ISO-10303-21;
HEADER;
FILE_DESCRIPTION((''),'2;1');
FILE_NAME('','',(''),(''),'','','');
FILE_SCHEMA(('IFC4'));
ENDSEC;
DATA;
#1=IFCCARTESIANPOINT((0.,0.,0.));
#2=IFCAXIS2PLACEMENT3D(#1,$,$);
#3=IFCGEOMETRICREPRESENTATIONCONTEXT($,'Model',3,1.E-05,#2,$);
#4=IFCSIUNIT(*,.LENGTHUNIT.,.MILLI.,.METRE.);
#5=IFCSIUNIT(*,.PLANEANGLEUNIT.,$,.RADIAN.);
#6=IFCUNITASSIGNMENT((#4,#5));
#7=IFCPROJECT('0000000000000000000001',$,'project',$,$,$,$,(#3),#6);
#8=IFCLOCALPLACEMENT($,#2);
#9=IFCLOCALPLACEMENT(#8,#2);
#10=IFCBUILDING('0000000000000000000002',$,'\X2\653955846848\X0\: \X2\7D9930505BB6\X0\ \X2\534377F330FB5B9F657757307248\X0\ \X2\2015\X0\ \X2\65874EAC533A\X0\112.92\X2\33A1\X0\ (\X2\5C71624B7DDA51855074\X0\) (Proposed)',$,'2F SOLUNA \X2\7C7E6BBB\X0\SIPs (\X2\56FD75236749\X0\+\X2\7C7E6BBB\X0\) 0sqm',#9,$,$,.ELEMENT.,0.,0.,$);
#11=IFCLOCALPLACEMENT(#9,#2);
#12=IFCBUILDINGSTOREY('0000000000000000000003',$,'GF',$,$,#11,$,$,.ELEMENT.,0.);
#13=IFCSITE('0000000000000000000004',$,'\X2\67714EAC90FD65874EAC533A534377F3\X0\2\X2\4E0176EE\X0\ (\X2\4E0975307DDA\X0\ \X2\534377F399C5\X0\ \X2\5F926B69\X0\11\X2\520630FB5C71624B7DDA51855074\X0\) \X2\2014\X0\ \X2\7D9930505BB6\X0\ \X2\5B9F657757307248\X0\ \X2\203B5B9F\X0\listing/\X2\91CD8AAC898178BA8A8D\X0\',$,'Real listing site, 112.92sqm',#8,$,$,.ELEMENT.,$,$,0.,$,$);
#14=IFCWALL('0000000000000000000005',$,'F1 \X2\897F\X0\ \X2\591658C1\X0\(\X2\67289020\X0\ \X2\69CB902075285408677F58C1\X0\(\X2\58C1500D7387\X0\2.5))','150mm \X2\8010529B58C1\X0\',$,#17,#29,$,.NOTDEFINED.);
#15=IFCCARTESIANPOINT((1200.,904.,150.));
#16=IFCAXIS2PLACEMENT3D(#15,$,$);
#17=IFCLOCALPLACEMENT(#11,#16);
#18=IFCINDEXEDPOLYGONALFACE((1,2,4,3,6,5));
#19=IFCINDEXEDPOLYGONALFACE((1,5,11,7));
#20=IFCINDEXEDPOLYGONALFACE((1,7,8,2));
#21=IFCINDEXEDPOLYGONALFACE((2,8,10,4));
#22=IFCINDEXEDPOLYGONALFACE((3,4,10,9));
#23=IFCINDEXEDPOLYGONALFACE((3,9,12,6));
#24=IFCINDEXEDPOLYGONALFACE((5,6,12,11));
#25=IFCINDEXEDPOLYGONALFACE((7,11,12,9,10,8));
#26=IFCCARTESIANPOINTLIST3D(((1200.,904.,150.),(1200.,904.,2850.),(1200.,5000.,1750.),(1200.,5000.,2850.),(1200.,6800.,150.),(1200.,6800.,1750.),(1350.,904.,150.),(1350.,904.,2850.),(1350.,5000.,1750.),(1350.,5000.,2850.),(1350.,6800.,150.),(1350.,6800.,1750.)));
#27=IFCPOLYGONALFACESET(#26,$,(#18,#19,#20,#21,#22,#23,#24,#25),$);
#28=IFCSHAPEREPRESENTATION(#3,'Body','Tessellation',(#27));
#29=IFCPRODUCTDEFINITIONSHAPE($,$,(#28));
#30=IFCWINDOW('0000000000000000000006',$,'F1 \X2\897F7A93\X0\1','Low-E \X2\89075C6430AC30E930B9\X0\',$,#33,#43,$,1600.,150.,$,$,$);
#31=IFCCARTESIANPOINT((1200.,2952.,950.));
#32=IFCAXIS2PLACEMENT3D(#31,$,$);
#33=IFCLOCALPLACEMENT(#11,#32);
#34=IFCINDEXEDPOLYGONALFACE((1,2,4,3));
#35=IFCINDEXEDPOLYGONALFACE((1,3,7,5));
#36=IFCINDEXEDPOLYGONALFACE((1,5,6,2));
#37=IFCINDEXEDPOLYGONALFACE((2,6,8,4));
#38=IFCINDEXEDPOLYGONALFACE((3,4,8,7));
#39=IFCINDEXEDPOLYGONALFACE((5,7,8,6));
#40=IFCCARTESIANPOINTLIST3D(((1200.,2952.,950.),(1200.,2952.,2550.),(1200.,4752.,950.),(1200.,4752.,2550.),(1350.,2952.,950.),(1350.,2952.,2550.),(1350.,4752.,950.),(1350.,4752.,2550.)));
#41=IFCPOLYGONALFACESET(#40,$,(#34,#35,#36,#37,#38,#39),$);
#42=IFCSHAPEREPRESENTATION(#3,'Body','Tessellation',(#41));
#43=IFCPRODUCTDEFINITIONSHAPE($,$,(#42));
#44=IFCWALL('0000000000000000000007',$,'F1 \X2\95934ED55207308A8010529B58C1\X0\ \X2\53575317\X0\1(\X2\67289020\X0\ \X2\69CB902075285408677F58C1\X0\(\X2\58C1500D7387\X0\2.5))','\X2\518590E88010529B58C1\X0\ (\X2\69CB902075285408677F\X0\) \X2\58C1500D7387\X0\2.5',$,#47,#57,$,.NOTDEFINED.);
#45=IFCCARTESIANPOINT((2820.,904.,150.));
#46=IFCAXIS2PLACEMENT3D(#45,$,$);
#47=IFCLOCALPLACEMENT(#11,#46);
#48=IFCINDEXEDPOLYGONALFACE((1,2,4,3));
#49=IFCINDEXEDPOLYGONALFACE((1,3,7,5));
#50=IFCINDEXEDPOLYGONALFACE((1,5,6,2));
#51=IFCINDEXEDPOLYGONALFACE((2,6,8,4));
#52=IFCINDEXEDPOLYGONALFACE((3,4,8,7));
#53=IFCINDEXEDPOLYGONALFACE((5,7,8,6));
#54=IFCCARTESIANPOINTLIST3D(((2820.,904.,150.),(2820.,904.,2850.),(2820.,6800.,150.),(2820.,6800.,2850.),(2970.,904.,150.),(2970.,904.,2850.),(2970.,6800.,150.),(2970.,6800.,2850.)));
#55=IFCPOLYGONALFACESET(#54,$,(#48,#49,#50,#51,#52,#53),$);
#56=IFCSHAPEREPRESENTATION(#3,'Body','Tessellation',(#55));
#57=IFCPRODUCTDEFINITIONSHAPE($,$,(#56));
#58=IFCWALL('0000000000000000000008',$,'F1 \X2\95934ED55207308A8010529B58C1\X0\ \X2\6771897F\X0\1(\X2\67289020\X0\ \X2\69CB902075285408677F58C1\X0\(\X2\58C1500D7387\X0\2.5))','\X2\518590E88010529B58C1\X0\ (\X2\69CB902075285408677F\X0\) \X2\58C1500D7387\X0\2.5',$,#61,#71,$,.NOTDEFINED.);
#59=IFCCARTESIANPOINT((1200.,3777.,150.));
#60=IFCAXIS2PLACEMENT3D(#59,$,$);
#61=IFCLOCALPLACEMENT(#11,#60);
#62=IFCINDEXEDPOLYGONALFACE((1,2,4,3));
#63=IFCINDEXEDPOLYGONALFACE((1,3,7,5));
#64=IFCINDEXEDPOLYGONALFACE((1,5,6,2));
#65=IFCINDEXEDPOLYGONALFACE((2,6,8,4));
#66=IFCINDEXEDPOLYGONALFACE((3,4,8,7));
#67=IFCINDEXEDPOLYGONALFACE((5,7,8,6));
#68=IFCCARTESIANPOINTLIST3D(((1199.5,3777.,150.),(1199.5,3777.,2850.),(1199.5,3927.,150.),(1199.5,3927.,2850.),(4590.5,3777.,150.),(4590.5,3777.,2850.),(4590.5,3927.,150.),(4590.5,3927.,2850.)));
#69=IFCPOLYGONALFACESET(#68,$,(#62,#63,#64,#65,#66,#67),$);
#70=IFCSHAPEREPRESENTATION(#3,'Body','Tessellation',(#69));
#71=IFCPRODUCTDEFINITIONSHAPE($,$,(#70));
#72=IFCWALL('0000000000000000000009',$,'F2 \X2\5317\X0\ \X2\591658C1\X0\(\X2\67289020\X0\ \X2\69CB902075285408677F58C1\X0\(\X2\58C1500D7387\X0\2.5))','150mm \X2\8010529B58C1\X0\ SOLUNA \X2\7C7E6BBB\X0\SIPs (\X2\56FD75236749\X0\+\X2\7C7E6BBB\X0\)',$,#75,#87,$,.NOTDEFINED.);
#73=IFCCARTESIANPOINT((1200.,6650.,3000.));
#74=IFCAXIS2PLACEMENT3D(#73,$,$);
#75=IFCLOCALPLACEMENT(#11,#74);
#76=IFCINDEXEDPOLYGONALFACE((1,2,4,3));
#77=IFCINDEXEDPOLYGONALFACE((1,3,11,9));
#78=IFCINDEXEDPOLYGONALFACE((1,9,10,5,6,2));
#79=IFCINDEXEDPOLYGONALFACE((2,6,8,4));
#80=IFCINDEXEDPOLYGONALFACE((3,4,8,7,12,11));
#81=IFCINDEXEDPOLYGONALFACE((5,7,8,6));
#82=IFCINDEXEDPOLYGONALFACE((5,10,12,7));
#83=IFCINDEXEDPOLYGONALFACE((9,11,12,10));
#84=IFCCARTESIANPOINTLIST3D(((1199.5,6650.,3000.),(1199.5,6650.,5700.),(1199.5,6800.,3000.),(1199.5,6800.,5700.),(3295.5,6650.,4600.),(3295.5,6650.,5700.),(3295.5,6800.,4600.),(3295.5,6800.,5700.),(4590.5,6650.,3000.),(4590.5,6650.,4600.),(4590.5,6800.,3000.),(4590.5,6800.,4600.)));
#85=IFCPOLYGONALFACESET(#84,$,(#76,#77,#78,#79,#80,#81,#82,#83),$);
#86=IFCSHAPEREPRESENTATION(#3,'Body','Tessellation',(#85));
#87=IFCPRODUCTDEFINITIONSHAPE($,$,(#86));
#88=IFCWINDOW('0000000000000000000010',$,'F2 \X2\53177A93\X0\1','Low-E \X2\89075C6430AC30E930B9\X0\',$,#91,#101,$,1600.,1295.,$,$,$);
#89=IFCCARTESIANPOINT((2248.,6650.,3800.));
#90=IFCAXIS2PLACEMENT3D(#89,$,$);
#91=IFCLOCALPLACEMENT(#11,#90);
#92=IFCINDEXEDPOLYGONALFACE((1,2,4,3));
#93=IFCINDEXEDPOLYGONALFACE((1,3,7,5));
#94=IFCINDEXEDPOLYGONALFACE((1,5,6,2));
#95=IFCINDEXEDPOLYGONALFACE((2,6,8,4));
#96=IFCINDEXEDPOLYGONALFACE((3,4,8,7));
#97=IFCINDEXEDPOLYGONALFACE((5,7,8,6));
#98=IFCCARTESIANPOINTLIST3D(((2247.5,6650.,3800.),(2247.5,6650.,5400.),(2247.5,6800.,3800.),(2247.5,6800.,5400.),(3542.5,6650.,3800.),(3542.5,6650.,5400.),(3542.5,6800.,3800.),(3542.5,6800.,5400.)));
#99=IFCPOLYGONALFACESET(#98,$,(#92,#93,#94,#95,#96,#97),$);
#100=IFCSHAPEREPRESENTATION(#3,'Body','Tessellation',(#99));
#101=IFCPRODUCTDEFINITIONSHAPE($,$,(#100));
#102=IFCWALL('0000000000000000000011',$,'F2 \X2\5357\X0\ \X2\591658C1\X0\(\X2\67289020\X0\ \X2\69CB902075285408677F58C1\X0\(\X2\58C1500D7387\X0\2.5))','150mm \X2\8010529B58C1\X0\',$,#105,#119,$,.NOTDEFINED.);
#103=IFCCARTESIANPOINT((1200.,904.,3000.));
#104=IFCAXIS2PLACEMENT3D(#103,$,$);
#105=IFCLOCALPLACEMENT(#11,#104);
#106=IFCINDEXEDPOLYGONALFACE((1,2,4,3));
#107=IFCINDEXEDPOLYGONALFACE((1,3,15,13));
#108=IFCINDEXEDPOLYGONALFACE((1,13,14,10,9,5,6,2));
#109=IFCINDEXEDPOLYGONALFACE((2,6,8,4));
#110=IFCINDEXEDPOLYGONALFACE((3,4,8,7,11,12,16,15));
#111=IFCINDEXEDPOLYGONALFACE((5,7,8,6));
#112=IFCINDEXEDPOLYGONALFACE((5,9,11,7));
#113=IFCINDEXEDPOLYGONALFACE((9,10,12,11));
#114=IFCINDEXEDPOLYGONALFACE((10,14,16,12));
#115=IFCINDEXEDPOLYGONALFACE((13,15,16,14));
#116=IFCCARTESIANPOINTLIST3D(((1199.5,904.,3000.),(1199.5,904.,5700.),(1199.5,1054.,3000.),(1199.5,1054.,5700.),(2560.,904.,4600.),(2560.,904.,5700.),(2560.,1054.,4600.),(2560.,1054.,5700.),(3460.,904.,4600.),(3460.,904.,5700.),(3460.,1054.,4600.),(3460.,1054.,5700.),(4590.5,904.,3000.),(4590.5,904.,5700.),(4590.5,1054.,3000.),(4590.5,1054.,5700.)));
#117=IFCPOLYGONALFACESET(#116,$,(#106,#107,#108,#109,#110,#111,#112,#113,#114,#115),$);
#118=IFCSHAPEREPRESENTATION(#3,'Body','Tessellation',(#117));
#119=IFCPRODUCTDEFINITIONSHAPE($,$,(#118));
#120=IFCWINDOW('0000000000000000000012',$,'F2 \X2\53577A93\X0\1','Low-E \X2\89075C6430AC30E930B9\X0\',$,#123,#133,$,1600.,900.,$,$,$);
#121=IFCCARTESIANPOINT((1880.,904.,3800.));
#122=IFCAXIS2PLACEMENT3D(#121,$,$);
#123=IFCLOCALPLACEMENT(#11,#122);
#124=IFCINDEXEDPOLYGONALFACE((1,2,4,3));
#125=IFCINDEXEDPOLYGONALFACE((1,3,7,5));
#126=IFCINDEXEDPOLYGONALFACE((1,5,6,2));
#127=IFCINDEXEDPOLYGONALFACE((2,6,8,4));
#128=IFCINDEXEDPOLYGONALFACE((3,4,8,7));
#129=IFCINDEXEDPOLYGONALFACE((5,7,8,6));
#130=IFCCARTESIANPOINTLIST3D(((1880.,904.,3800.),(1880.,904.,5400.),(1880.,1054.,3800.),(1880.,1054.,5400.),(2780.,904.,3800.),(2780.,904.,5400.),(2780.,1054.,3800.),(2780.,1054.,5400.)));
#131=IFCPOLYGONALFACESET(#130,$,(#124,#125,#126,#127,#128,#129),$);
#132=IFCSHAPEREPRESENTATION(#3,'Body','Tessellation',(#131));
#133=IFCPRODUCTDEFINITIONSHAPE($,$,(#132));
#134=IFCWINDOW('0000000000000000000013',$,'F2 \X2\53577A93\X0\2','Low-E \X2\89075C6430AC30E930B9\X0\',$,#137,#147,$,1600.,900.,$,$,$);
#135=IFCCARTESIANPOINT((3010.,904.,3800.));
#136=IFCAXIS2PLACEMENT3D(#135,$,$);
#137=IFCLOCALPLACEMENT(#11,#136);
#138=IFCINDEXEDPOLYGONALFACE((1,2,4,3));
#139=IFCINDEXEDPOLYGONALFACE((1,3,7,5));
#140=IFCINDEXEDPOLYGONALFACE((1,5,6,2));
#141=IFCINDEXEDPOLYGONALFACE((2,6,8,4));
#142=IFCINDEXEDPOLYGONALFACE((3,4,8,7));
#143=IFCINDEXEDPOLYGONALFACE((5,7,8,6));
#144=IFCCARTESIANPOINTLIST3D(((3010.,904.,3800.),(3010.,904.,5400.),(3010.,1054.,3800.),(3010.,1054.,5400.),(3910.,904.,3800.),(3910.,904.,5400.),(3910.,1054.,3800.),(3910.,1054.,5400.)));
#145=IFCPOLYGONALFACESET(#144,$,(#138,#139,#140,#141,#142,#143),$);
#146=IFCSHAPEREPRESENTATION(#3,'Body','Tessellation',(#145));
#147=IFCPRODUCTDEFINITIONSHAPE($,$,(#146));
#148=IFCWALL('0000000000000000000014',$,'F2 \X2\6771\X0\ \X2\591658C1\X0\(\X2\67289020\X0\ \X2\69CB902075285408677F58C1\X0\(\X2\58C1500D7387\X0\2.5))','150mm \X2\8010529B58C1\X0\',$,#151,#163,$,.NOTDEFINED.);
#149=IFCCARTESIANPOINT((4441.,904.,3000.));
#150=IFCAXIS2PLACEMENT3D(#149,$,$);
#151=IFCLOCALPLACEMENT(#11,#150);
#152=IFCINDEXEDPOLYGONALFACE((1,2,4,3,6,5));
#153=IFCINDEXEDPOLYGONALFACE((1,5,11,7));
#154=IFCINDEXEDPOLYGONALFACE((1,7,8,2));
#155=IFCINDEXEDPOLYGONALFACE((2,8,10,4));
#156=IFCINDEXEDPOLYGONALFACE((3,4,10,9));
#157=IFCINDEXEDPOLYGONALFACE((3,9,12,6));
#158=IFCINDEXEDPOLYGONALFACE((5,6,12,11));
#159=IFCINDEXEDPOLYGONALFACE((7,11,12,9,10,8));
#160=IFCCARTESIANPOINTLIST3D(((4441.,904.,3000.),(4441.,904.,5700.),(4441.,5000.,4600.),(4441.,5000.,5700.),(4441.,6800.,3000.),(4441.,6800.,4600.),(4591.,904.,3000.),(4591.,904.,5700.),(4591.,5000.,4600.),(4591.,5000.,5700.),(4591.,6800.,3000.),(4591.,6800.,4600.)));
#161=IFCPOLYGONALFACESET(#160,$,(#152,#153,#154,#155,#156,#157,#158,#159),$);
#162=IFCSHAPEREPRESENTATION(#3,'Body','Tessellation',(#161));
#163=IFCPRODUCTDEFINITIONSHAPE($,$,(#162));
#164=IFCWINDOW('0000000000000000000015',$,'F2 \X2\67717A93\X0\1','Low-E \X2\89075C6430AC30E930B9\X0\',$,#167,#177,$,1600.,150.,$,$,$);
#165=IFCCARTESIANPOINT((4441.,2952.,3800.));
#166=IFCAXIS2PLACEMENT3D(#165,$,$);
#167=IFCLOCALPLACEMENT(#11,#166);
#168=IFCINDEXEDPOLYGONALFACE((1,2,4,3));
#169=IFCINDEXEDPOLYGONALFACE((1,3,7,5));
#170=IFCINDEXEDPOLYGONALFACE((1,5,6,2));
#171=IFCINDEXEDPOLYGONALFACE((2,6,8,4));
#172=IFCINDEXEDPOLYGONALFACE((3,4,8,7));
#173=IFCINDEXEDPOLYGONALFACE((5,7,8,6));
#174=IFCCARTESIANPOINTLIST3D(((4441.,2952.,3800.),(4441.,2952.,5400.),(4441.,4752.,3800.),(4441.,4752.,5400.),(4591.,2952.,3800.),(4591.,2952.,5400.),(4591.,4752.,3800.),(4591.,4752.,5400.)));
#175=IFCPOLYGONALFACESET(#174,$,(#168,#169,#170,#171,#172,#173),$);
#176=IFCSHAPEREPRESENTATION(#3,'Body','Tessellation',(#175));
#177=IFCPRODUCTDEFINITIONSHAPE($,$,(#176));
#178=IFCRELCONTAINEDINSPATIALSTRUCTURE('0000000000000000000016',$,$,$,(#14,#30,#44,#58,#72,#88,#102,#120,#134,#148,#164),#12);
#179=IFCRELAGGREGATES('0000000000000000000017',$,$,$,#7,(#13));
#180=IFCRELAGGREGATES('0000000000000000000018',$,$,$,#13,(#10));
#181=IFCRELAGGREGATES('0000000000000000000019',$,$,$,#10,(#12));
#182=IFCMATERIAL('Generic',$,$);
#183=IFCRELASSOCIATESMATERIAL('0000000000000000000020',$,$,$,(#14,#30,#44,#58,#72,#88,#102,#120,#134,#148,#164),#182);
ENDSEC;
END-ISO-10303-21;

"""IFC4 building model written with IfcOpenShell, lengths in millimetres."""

from ifc_helpers import new_model, si_unit, frame, frame_2d, origin, place, context, project, spatial, rectangle, extrude, material, element, fill, save


model = new_model("IFC4")

# Units and contexts
model_context = context("Model", 3, precision=1e-05, world=origin())
ifc_project = project(units=[si_unit("LENGTHUNIT", "METRE", prefix="MILLI"), si_unit("PLANEANGLEUNIT", "RADIAN")], contexts=[model_context])

# Site, building, storey
site_placement = place(None, origin())
site = spatial("IfcSite", under=ifc_project, at=site_placement, Name="東京都文京区千石2丁目 (三田線 千石駅 徒歩11分・山手線内側) — 継ぐ家 実敷地版 ※実listing/重説要確認", ObjectType="Real listing site, 112.92sqm", CompositionType="ELEMENT", RefElevation=0.0)
building_placement = place(site_placement, origin())
building = spatial("IfcBuilding", under=site, at=building_placement, Name="改善案: 継ぐ家 千石・実敷地版 ― 文京区112.92㎡ (山手線内側) (Proposed)", ObjectType="2F SOLUNA 籾殻SIPs (国産杉+籾殻) 0sqm", CompositionType="ELEMENT", ElevationOfRefHeight=0.0, ElevationOfTerrain=0.0)
storey_placement = place(building_placement, origin())
storey = spatial("IfcBuildingStorey", under=building, at=storey_placement, Name="GF", CompositionType="ELEMENT", Elevation=0.0)

# Shared definitions
ifc_material_1 = material(Name="Generic")

# Wall, opening, window
wall_1_placement = place(storey_placement, frame((1200.0, 904.0, 150.0)))
wall_1 = element("IfcWall", 1, at=wall_1_placement, inside=storey, material=ifc_material_1, Name="F1 西 外壁(木造 構造用合板壁(壁倍率2.5))", Description="150mm 耐力壁", PredefinedType="NOTDEFINED", context=model_context, shape_type="SweptSolid", body=[
    extrude(rectangle(XDim=150.0, YDim=5896.0, at=frame_2d((75.0, 2948.0))), frame((1200.0, 904.0, 150.0)), (0.0, 0.0, 1.0), 2700.0),
])
opening_1_placement = place(storey_placement, frame((1200.0, 2952.0, 950.0)))
opening_1 = element("IfcOpeningElement", 2, at=opening_1_placement, cuts=wall_1, PredefinedType="NOTDEFINED", context=model_context, shape_type="SweptSolid", body=[
    extrude(rectangle(XDim=150.0, YDim=1800.0, at=frame_2d((75.0, 900.0))), frame((1200.0, 2952.0, 950.0)), (0.0, 0.0, 1.0), 1600.0),
])
window_1_placement = place(storey_placement, frame((1200.0, 2952.0, 950.0)))
window_1 = element("IfcWindow", 3, at=window_1_placement, inside=storey, material=ifc_material_1, Name="F1 西窓1", Description="Low-E 複層ガラス", OverallHeight=1600.0, OverallWidth=150.0, context=model_context, shape_type="SweptSolid", body=[
    extrude(rectangle(XDim=150.0, YDim=1800.0, at=frame_2d((75.0, 900.0))), frame((1200.0, 2952.0, 950.0)), (0.0, 0.0, 1.0), 1600.0),
])
fill(opening_1, window_1)

# Walls
wall_2_placement = place(storey_placement, frame((2820.0, 904.0, 150.0)))
element("IfcWall", 4, at=wall_2_placement, inside=storey, material=ifc_material_1, Name="F1 間仕切り耐力壁 南北1(木造 構造用合板壁(壁倍率2.5))", Description="内部耐力壁 (構造用合板) 壁倍率2.5", PredefinedType="NOTDEFINED", context=model_context, shape_type="SweptSolid", body=[
    extrude(rectangle(XDim=150.0, YDim=5896.0, at=frame_2d((75.0, 2948.0))), frame((2820.0, 904.0, 150.0)), (0.0, 0.0, 1.0), 2700.0),
])
wall_3_placement = place(storey_placement, frame((1200.0, 3777.0, 150.0)))
element("IfcWall", 5, at=wall_3_placement, inside=storey, material=ifc_material_1, Name="F1 間仕切り耐力壁 東西1(木造 構造用合板壁(壁倍率2.5))", Description="内部耐力壁 (構造用合板) 壁倍率2.5", PredefinedType="NOTDEFINED", context=model_context, shape_type="SweptSolid", body=[
    extrude(rectangle(XDim=3391.0, YDim=150.0, at=frame_2d((1695.0, 75.0))), frame((1200.0, 3777.0, 150.0)), (0.0, 0.0, 1.0), 2700.0),
])

# Wall, opening, window
wall_4_placement = place(storey_placement, frame((1200.0, 6650.0, 3000.0)))
wall_4 = element("IfcWall", 6, at=wall_4_placement, inside=storey, material=ifc_material_1, Name="F2 北 外壁(木造 構造用合板壁(壁倍率2.5))", Description="150mm 耐力壁 SOLUNA 籾殻SIPs (国産杉+籾殻)", PredefinedType="NOTDEFINED", context=model_context, shape_type="SweptSolid", body=[
    extrude(rectangle(XDim=3391.0, YDim=150.0, at=frame_2d((1695.0, 75.0))), frame((1200.0, 6650.0, 3000.0)), (0.0, 0.0, 1.0), 2700.0),
])
opening_2_placement = place(storey_placement, frame((2248.0, 6650.0, 3800.0)))
opening_2 = element("IfcOpeningElement", 7, at=opening_2_placement, cuts=wall_4, PredefinedType="NOTDEFINED", context=model_context, shape_type="SweptSolid", body=[
    extrude(rectangle(XDim=1295.0, YDim=150.0, at=frame_2d((647.0, 75.0))), frame((2248.0, 6650.0, 3800.0)), (0.0, 0.0, 1.0), 1600.0),
])
window_2_placement = place(storey_placement, frame((2248.0, 6650.0, 3800.0)))
window_2 = element("IfcWindow", 8, at=window_2_placement, inside=storey, material=ifc_material_1, Name="F2 北窓1", Description="Low-E 複層ガラス", OverallHeight=1600.0, OverallWidth=1295.0, context=model_context, shape_type="SweptSolid", body=[
    extrude(rectangle(XDim=1295.0, YDim=150.0, at=frame_2d((647.0, 75.0))), frame((2248.0, 6650.0, 3800.0)), (0.0, 0.0, 1.0), 1600.0),
])
fill(opening_2, window_2)

# Wall, openings, windows
wall_5_placement = place(storey_placement, frame((1200.0, 904.0, 3000.0)))
wall_5 = element("IfcWall", 9, at=wall_5_placement, inside=storey, material=ifc_material_1, Name="F2 南 外壁(木造 構造用合板壁(壁倍率2.5))", Description="150mm 耐力壁", PredefinedType="NOTDEFINED", context=model_context, shape_type="SweptSolid", body=[
    extrude(rectangle(XDim=3391.0, YDim=150.0, at=frame_2d((1695.0, 75.0))), frame((1200.0, 904.0, 3000.0)), (0.0, 0.0, 1.0), 2700.0),
])
opening_3_placement = place(storey_placement, frame((1880.0, 904.0, 3800.0)))
opening_3 = element("IfcOpeningElement", 10, at=opening_3_placement, cuts=wall_5, PredefinedType="NOTDEFINED", context=model_context, shape_type="SweptSolid", body=[
    extrude(rectangle(XDim=900.0, YDim=150.0, at=frame_2d((450.0, 75.0))), frame((1880.0, 904.0, 3800.0)), (0.0, 0.0, 1.0), 1600.0),
])
opening_4_placement = place(storey_placement, frame((3010.0, 904.0, 3800.0)))
opening_4 = element("IfcOpeningElement", 11, at=opening_4_placement, cuts=wall_5, PredefinedType="NOTDEFINED", context=model_context, shape_type="SweptSolid", body=[
    extrude(rectangle(XDim=900.0, YDim=150.0, at=frame_2d((450.0, 75.0))), frame((3010.0, 904.0, 3800.0)), (0.0, 0.0, 1.0), 1600.0),
])
window_3_placement = place(storey_placement, frame((1880.0, 904.0, 3800.0)))
window_3 = element("IfcWindow", 12, at=window_3_placement, inside=storey, material=ifc_material_1, Name="F2 南窓1", Description="Low-E 複層ガラス", OverallHeight=1600.0, OverallWidth=900.0, context=model_context, shape_type="SweptSolid", body=[
    extrude(rectangle(XDim=900.0, YDim=150.0, at=frame_2d((450.0, 75.0))), frame((1880.0, 904.0, 3800.0)), (0.0, 0.0, 1.0), 1600.0),
])
fill(opening_3, window_3)
window_4_placement = place(storey_placement, frame((3010.0, 904.0, 3800.0)))
window_4 = element("IfcWindow", 13, at=window_4_placement, inside=storey, material=ifc_material_1, Name="F2 南窓2", Description="Low-E 複層ガラス", OverallHeight=1600.0, OverallWidth=900.0, context=model_context, shape_type="SweptSolid", body=[
    extrude(rectangle(XDim=900.0, YDim=150.0, at=frame_2d((450.0, 75.0))), frame((3010.0, 904.0, 3800.0)), (0.0, 0.0, 1.0), 1600.0),
])
fill(opening_4, window_4)

# Wall, opening, window
wall_6_placement = place(storey_placement, frame((4441.0, 904.0, 3000.0)))
wall_6 = element("IfcWall", 14, at=wall_6_placement, inside=storey, material=ifc_material_1, Name="F2 東 外壁(木造 構造用合板壁(壁倍率2.5))", Description="150mm 耐力壁", PredefinedType="NOTDEFINED", context=model_context, shape_type="SweptSolid", body=[
    extrude(rectangle(XDim=150.0, YDim=5896.0, at=frame_2d((75.0, 2948.0))), frame((4441.0, 904.0, 3000.0)), (0.0, 0.0, 1.0), 2700.0),
])
opening_5_placement = place(storey_placement, frame((4441.0, 2952.0, 3800.0)))
opening_5 = element("IfcOpeningElement", 15, at=opening_5_placement, cuts=wall_6, PredefinedType="NOTDEFINED", context=model_context, shape_type="SweptSolid", body=[
    extrude(rectangle(XDim=150.0, YDim=1800.0, at=frame_2d((75.0, 900.0))), frame((4441.0, 2952.0, 3800.0)), (0.0, 0.0, 1.0), 1600.0),
])
window_5_placement = place(storey_placement, frame((4441.0, 2952.0, 3800.0)))
window_5 = element("IfcWindow", 16, at=window_5_placement, inside=storey, material=ifc_material_1, Name="F2 東窓1", Description="Low-E 複層ガラス", OverallHeight=1600.0, OverallWidth=150.0, context=model_context, shape_type="SweptSolid", body=[
    extrude(rectangle(XDim=150.0, YDim=1800.0, at=frame_2d((75.0, 900.0))), frame((4441.0, 2952.0, 3800.0)), (0.0, 0.0, 1.0), 1600.0),
])
fill(opening_5, window_5)

save(model, "model.ifc")
